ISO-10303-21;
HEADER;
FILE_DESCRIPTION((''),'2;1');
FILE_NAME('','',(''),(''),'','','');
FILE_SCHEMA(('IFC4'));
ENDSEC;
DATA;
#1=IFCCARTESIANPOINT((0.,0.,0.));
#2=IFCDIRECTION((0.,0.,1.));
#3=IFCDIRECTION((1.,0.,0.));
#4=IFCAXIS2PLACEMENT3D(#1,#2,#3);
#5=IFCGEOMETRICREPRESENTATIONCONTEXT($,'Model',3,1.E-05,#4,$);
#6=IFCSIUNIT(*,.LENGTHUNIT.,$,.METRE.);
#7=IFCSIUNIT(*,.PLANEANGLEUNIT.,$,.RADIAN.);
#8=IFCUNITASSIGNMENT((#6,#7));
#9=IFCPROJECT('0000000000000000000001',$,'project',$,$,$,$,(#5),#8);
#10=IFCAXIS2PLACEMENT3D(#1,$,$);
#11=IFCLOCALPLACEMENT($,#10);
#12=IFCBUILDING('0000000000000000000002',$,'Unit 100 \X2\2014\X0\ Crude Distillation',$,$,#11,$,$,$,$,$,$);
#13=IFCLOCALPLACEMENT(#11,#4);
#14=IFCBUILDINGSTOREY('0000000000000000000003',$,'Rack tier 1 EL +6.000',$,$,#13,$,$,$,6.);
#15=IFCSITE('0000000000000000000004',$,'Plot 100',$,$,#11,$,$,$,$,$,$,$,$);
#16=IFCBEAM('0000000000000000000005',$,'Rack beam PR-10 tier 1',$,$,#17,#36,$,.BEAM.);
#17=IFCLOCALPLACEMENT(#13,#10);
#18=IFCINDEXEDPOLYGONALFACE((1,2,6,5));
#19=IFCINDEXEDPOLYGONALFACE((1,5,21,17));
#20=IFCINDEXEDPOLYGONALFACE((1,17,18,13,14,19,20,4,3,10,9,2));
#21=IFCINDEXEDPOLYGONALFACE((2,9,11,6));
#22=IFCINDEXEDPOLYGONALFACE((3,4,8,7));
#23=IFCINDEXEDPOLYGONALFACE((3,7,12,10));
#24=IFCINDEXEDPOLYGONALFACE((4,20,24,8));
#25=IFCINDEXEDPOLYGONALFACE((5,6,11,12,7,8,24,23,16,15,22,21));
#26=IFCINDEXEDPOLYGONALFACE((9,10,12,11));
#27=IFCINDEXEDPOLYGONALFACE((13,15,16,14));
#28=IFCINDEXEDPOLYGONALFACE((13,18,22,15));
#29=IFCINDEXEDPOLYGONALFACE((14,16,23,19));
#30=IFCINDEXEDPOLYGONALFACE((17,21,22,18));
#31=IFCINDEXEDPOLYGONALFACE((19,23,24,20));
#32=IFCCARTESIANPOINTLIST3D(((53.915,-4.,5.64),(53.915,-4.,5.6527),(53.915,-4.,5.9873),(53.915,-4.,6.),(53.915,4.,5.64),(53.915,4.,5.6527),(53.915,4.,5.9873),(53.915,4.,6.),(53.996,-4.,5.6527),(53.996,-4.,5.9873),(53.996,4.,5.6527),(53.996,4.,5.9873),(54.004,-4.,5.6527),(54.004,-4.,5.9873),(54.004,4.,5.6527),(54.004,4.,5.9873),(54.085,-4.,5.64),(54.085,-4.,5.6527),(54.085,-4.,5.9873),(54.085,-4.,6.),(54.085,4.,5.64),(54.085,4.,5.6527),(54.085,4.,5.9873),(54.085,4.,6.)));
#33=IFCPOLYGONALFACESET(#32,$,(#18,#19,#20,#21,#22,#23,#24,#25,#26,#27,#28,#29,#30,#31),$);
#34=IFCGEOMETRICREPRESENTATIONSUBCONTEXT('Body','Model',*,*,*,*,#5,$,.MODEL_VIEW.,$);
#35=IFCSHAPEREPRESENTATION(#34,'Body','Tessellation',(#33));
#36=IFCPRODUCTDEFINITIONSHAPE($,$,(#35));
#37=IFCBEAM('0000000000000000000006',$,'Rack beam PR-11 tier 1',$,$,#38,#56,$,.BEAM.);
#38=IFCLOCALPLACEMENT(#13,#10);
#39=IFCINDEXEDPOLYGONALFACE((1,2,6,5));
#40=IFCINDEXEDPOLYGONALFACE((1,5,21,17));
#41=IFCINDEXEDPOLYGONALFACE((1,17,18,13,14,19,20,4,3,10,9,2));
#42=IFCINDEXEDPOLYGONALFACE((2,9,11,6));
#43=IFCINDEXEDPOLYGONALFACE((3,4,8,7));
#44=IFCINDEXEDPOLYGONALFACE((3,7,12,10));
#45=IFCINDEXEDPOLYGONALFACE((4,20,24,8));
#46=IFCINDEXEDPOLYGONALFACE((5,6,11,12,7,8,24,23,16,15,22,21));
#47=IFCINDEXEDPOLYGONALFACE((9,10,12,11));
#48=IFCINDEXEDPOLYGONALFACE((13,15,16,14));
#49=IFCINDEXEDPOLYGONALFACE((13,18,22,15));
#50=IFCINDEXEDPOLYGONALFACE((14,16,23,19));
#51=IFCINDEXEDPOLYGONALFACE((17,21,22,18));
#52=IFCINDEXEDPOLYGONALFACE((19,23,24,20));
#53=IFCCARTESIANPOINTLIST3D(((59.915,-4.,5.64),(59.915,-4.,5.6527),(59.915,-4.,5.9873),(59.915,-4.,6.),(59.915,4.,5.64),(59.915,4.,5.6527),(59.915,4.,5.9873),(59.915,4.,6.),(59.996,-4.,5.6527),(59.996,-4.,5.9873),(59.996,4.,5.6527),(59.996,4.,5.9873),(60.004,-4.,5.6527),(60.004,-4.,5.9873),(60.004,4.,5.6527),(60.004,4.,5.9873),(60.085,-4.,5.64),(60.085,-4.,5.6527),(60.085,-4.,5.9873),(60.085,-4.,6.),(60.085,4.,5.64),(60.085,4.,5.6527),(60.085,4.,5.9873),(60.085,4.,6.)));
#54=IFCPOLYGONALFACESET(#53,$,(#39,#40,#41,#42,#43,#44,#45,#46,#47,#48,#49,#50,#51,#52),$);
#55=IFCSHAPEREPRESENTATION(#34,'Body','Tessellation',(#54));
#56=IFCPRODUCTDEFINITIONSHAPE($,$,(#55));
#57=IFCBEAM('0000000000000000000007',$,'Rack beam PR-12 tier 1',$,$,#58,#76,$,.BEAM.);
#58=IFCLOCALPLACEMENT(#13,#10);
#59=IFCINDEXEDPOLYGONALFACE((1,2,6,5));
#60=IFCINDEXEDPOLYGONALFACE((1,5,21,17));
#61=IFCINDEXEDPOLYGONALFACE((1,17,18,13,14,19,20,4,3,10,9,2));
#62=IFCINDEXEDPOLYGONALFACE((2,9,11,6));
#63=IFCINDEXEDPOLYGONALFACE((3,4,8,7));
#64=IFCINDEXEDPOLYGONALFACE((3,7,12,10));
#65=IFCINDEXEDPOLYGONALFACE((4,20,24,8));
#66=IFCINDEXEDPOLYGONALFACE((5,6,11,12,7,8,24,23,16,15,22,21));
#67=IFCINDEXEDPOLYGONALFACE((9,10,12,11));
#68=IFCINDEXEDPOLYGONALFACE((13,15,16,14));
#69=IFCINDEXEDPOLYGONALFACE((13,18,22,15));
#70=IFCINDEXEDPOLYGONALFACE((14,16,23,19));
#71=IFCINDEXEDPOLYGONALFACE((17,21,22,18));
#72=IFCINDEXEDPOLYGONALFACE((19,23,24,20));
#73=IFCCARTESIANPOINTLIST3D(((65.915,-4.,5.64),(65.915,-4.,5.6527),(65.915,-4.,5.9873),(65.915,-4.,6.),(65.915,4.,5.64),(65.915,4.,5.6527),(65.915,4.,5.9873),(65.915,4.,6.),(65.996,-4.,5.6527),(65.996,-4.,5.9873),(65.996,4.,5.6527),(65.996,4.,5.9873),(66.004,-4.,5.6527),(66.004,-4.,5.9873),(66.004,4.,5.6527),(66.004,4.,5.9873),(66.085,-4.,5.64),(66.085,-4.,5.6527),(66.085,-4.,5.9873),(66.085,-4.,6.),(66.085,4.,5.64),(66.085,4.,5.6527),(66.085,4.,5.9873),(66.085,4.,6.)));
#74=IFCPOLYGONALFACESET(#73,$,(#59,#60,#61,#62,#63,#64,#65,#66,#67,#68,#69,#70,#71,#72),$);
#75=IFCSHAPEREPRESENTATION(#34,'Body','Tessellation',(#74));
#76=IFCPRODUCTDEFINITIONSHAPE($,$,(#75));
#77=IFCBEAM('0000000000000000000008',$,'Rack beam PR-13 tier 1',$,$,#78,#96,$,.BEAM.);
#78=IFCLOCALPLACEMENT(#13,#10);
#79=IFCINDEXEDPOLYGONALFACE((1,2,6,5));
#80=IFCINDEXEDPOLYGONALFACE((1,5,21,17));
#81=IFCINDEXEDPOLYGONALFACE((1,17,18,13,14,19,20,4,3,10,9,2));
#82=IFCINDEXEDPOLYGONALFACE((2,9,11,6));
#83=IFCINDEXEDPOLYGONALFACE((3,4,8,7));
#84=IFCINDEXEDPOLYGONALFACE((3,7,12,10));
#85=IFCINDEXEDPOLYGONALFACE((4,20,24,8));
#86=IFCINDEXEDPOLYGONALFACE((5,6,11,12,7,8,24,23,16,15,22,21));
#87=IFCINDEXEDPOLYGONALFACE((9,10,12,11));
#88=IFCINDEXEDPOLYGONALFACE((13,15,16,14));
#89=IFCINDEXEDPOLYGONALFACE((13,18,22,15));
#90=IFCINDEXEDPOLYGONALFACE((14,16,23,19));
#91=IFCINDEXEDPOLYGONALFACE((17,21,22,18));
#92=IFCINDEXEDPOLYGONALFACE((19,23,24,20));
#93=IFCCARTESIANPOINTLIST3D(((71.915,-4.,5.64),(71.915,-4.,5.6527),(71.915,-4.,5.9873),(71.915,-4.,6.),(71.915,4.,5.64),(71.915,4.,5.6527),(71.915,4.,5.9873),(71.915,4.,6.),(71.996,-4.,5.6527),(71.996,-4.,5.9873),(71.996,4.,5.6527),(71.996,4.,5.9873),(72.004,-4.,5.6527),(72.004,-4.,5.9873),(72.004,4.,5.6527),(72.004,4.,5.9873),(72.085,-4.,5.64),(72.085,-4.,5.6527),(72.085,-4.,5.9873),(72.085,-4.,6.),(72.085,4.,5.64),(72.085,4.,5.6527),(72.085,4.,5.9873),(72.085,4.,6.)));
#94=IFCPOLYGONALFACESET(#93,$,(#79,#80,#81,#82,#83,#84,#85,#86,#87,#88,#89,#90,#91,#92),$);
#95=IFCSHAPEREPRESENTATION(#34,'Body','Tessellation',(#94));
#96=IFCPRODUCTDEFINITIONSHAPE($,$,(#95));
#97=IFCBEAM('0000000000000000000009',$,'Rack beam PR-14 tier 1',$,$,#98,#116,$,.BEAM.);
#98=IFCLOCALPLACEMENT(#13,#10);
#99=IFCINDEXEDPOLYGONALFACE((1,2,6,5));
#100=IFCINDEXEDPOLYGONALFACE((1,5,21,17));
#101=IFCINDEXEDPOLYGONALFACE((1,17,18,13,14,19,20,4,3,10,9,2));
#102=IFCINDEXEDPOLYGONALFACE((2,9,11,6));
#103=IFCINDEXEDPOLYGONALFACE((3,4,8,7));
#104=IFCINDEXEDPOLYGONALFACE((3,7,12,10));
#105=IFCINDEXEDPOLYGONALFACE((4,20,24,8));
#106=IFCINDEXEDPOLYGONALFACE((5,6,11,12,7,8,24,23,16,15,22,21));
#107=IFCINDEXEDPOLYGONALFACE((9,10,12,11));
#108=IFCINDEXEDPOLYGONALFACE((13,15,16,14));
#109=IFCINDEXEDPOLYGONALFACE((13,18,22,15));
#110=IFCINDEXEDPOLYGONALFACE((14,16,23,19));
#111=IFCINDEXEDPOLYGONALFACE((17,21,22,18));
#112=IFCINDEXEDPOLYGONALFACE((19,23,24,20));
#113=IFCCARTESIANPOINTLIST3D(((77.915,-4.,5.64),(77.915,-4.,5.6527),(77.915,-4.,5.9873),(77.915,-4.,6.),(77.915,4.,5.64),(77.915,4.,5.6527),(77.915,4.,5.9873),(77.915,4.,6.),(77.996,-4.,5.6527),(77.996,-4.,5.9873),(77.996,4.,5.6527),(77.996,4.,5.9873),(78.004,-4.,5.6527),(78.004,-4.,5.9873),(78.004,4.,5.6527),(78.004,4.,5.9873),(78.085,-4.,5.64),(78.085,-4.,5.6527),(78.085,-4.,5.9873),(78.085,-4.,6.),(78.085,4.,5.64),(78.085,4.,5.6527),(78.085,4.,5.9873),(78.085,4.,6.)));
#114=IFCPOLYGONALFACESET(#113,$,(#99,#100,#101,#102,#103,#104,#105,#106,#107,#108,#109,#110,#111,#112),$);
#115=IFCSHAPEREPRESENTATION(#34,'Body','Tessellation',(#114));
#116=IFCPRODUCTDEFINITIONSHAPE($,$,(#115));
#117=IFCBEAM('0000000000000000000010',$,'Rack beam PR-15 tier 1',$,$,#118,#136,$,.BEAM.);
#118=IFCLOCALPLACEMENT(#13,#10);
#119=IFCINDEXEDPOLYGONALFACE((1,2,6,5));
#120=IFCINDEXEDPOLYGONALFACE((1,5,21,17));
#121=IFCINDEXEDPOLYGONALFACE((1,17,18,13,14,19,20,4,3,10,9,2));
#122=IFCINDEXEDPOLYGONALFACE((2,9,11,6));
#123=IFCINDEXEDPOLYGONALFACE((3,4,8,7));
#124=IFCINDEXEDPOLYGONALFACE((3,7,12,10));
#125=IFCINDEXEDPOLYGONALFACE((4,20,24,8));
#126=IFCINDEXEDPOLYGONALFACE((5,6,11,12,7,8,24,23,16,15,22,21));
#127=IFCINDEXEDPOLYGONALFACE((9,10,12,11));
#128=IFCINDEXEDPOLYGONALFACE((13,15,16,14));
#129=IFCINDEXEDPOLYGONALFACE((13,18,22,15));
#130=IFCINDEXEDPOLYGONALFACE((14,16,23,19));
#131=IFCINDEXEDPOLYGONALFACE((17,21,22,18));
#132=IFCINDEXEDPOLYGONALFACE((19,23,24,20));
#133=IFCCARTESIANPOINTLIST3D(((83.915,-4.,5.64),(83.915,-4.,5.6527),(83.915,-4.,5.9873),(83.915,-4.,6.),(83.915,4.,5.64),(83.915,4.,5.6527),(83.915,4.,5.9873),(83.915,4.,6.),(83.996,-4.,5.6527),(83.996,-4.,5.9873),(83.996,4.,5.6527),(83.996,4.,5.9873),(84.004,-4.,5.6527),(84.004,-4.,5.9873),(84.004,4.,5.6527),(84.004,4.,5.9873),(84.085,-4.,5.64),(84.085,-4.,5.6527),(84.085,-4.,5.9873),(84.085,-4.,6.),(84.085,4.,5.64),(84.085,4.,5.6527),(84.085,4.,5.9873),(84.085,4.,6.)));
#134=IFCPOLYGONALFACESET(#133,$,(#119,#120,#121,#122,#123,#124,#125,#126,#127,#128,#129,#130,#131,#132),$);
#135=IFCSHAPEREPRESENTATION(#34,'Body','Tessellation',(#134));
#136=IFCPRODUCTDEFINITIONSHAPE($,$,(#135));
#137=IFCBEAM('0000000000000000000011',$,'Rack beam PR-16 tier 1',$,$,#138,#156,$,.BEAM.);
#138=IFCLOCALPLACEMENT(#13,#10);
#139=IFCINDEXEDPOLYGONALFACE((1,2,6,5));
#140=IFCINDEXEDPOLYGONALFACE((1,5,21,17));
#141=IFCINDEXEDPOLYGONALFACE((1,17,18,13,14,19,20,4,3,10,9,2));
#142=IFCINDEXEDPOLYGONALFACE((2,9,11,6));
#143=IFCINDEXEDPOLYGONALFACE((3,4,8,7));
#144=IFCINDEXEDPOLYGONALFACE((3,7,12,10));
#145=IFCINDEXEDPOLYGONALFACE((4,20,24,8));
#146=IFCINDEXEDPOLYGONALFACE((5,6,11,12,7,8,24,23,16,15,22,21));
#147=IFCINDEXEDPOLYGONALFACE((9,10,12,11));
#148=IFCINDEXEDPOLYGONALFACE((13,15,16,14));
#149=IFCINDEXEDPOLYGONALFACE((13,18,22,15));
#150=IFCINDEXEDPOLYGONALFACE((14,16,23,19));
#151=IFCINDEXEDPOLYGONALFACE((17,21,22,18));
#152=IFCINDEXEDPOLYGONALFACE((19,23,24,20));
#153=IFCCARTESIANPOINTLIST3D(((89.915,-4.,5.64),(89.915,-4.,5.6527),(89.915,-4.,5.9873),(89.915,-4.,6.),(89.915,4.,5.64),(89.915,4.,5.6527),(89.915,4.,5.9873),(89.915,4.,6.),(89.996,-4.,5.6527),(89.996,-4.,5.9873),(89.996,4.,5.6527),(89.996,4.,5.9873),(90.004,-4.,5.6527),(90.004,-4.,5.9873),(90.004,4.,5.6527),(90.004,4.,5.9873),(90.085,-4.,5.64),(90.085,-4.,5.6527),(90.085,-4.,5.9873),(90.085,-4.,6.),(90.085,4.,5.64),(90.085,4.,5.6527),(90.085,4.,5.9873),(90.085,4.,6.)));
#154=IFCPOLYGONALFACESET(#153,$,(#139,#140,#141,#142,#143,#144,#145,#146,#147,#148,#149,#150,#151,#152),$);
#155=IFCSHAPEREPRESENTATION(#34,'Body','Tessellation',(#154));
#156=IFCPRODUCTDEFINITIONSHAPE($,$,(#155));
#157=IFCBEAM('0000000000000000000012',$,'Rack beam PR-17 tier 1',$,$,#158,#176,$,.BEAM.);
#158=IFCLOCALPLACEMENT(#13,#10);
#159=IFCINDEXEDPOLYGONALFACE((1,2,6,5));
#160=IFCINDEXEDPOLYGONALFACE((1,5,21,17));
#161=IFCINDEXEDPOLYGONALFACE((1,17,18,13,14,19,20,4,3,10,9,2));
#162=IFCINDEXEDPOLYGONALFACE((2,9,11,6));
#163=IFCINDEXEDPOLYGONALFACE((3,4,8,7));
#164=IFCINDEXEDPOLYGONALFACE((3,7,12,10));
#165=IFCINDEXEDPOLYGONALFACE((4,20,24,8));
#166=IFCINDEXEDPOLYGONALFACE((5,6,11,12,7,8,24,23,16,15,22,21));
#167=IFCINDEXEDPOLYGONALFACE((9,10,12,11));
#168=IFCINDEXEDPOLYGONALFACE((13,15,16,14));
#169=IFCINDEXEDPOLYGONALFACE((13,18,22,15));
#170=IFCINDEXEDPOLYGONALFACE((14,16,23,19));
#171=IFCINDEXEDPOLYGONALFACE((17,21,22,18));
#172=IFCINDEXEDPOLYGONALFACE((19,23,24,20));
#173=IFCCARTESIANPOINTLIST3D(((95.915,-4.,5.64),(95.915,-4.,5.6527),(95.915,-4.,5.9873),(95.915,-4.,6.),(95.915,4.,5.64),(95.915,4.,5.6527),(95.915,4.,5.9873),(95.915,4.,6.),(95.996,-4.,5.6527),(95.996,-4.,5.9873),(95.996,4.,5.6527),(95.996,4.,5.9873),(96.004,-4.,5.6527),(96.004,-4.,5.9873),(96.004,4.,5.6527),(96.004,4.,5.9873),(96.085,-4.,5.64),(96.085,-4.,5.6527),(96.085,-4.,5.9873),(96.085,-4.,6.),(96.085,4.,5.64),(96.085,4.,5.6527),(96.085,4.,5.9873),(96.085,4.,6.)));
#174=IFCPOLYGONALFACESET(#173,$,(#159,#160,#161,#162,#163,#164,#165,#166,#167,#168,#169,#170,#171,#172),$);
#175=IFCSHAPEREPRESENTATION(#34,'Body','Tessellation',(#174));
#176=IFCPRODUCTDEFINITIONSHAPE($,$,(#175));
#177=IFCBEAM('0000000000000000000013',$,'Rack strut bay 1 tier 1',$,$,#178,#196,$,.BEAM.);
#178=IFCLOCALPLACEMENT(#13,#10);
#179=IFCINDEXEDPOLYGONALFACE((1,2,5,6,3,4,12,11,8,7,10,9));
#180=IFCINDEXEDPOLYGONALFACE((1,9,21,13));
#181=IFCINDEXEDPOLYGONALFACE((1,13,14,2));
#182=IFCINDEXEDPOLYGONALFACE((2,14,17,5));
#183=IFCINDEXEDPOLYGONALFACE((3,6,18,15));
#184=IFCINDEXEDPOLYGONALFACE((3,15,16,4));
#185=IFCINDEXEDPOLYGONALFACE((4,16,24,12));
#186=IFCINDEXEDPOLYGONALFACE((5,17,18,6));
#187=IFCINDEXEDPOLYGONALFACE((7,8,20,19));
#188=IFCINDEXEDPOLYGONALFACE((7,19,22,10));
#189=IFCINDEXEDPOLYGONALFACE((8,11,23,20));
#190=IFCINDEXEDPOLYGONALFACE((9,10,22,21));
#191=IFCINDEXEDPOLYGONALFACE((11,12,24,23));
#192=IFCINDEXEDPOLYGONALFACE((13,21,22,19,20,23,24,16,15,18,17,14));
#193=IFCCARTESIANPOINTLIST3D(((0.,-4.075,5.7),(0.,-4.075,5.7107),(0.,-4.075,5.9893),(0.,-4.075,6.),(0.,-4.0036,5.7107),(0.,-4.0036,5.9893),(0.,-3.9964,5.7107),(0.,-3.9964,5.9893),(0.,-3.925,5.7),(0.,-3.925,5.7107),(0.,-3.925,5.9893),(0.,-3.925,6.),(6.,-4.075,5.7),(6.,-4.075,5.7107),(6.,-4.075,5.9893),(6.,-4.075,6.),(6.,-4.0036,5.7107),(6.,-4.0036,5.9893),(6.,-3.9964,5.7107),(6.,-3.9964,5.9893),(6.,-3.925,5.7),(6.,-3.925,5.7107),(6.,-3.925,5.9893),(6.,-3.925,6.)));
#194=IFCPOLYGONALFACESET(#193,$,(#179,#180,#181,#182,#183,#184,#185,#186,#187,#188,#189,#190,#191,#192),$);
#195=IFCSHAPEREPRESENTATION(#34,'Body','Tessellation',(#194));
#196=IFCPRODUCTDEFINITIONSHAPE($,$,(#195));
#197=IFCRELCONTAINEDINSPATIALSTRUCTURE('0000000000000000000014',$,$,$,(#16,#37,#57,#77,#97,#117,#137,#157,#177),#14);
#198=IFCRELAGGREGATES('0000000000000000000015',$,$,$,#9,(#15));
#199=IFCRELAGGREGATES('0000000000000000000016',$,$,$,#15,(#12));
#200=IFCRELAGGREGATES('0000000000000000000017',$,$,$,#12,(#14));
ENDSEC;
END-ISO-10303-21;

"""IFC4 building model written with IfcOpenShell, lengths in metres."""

from ifc_helpers import new_model, si_unit, frame, origin, origin_with_axes, origin_2d, place, context, subcontext, project, spatial, i_section, extrude, element, save


model = new_model("IFC4")

# Units and contexts
model_context = context("Model", 3, precision=1e-05, world=origin_with_axes())
body_context = subcontext(model_context, "Body", "Model", "MODEL_VIEW")
ifc_project = project(units=[si_unit("LENGTHUNIT", "METRE"), si_unit("PLANEANGLEUNIT", "RADIAN")], contexts=[model_context])

# Site, building, storey
placement = place(None, origin())
site = spatial("IfcSite", under=ifc_project, at=placement, Name="Plot 100")
building = spatial("IfcBuilding", under=site, at=placement, Name="Unit 100 — Crude Distillation")
storey_placement = place(placement, origin_with_axes())
storey = spatial("IfcBuildingStorey", under=building, at=storey_placement, Name="Rack tier 1 EL +6.000", Elevation=6.0)

# Beams
beam_1_placement = place(storey_placement, origin_with_axes())
element("IfcBeam", 1, at=beam_1_placement, inside=storey, Name="Rack beam PR-10 tier 1", PredefinedType="BEAM", context=body_context, shape_type="SweptSolid", body=[
    extrude(i_section(OverallWidth=0.17, OverallDepth=0.36, WebThickness=0.008, FlangeThickness=0.0127, at=origin_2d()), frame((54.0, -4.0, 5.82), z_axis=(0.0, 1.0, 0.0), x_axis=(-1.0, 0.0, 0.0)), (0.0, 0.0, 1.0), 8.0),
])
beam_2_placement = place(storey_placement, origin_with_axes())
element("IfcBeam", 2, at=beam_2_placement, inside=storey, Name="Rack beam PR-11 tier 1", PredefinedType="BEAM", context=body_context, shape_type="SweptSolid", body=[
    extrude(i_section(OverallWidth=0.17, OverallDepth=0.36, WebThickness=0.008, FlangeThickness=0.0127, at=origin_2d()), frame((60.0, -4.0, 5.82), z_axis=(0.0, 1.0, 0.0), x_axis=(-1.0, 0.0, 0.0)), (0.0, 0.0, 1.0), 8.0),
])
beam_3_placement = place(storey_placement, origin_with_axes())
element("IfcBeam", 3, at=beam_3_placement, inside=storey, Name="Rack beam PR-12 tier 1", PredefinedType="BEAM", context=body_context, shape_type="SweptSolid", body=[
    extrude(i_section(OverallWidth=0.17, OverallDepth=0.36, WebThickness=0.008, FlangeThickness=0.0127, at=origin_2d()), frame((66.0, -4.0, 5.82), z_axis=(0.0, 1.0, 0.0), x_axis=(-1.0, 0.0, 0.0)), (0.0, 0.0, 1.0), 8.0),
])
beam_4_placement = place(storey_placement, origin_with_axes())
element("IfcBeam", 4, at=beam_4_placement, inside=storey, Name="Rack beam PR-13 tier 1", PredefinedType="BEAM", context=body_context, shape_type="SweptSolid", body=[
    extrude(i_section(OverallWidth=0.17, OverallDepth=0.36, WebThickness=0.008, FlangeThickness=0.0127, at=origin_2d()), frame((72.0, -4.0, 5.82), z_axis=(0.0, 1.0, 0.0), x_axis=(-1.0, 0.0, 0.0)), (0.0, 0.0, 1.0), 8.0),
])
beam_5_placement = place(storey_placement, origin_with_axes())
element("IfcBeam", 5, at=beam_5_placement, inside=storey, Name="Rack beam PR-14 tier 1", PredefinedType="BEAM", context=body_context, shape_type="SweptSolid", body=[
    extrude(i_section(OverallWidth=0.17, OverallDepth=0.36, WebThickness=0.008, FlangeThickness=0.0127, at=origin_2d()), frame((78.0, -4.0, 5.82), z_axis=(0.0, 1.0, 0.0), x_axis=(-1.0, 0.0, 0.0)), (0.0, 0.0, 1.0), 8.0),
])
beam_6_placement = place(storey_placement, origin_with_axes())
element("IfcBeam", 6, at=beam_6_placement, inside=storey, Name="Rack beam PR-15 tier 1", PredefinedType="BEAM", context=body_context, shape_type="SweptSolid", body=[
    extrude(i_section(OverallWidth=0.17, OverallDepth=0.36, WebThickness=0.008, FlangeThickness=0.0127, at=origin_2d()), frame((84.0, -4.0, 5.82), z_axis=(0.0, 1.0, 0.0), x_axis=(-1.0, 0.0, 0.0)), (0.0, 0.0, 1.0), 8.0),
])
beam_7_placement = place(storey_placement, origin_with_axes())
element("IfcBeam", 7, at=beam_7_placement, inside=storey, Name="Rack beam PR-16 tier 1", PredefinedType="BEAM", context=body_context, shape_type="SweptSolid", body=[
    extrude(i_section(OverallWidth=0.17, OverallDepth=0.36, WebThickness=0.008, FlangeThickness=0.0127, at=origin_2d()), frame((90.0, -4.0, 5.82), z_axis=(0.0, 1.0, 0.0), x_axis=(-1.0, 0.0, 0.0)), (0.0, 0.0, 1.0), 8.0),
])
beam_8_placement = place(storey_placement, origin_with_axes())
element("IfcBeam", 8, at=beam_8_placement, inside=storey, Name="Rack beam PR-17 tier 1", PredefinedType="BEAM", context=body_context, shape_type="SweptSolid", body=[
    extrude(i_section(OverallWidth=0.17, OverallDepth=0.36, WebThickness=0.008, FlangeThickness=0.0127, at=origin_2d()), frame((96.0, -4.0, 5.82), z_axis=(0.0, 1.0, 0.0), x_axis=(-1.0, 0.0, 0.0)), (0.0, 0.0, 1.0), 8.0),
])
beam_9_placement = place(storey_placement, origin_with_axes())
element("IfcBeam", 9, at=beam_9_placement, inside=storey, Name="Rack strut bay 1 tier 1", PredefinedType="BEAM", context=body_context, shape_type="SweptSolid", body=[
    extrude(i_section(OverallWidth=0.15, OverallDepth=0.3, WebThickness=0.0071, FlangeThickness=0.0107, at=origin_2d()), frame((0.0, -4.0, 5.85), z_axis=(1.0, 0.0, 0.0), x_axis=(0.0, 1.0, 0.0)), (0.0, 0.0, 1.0), 6.0),
])

save(model, "model.ifc")
